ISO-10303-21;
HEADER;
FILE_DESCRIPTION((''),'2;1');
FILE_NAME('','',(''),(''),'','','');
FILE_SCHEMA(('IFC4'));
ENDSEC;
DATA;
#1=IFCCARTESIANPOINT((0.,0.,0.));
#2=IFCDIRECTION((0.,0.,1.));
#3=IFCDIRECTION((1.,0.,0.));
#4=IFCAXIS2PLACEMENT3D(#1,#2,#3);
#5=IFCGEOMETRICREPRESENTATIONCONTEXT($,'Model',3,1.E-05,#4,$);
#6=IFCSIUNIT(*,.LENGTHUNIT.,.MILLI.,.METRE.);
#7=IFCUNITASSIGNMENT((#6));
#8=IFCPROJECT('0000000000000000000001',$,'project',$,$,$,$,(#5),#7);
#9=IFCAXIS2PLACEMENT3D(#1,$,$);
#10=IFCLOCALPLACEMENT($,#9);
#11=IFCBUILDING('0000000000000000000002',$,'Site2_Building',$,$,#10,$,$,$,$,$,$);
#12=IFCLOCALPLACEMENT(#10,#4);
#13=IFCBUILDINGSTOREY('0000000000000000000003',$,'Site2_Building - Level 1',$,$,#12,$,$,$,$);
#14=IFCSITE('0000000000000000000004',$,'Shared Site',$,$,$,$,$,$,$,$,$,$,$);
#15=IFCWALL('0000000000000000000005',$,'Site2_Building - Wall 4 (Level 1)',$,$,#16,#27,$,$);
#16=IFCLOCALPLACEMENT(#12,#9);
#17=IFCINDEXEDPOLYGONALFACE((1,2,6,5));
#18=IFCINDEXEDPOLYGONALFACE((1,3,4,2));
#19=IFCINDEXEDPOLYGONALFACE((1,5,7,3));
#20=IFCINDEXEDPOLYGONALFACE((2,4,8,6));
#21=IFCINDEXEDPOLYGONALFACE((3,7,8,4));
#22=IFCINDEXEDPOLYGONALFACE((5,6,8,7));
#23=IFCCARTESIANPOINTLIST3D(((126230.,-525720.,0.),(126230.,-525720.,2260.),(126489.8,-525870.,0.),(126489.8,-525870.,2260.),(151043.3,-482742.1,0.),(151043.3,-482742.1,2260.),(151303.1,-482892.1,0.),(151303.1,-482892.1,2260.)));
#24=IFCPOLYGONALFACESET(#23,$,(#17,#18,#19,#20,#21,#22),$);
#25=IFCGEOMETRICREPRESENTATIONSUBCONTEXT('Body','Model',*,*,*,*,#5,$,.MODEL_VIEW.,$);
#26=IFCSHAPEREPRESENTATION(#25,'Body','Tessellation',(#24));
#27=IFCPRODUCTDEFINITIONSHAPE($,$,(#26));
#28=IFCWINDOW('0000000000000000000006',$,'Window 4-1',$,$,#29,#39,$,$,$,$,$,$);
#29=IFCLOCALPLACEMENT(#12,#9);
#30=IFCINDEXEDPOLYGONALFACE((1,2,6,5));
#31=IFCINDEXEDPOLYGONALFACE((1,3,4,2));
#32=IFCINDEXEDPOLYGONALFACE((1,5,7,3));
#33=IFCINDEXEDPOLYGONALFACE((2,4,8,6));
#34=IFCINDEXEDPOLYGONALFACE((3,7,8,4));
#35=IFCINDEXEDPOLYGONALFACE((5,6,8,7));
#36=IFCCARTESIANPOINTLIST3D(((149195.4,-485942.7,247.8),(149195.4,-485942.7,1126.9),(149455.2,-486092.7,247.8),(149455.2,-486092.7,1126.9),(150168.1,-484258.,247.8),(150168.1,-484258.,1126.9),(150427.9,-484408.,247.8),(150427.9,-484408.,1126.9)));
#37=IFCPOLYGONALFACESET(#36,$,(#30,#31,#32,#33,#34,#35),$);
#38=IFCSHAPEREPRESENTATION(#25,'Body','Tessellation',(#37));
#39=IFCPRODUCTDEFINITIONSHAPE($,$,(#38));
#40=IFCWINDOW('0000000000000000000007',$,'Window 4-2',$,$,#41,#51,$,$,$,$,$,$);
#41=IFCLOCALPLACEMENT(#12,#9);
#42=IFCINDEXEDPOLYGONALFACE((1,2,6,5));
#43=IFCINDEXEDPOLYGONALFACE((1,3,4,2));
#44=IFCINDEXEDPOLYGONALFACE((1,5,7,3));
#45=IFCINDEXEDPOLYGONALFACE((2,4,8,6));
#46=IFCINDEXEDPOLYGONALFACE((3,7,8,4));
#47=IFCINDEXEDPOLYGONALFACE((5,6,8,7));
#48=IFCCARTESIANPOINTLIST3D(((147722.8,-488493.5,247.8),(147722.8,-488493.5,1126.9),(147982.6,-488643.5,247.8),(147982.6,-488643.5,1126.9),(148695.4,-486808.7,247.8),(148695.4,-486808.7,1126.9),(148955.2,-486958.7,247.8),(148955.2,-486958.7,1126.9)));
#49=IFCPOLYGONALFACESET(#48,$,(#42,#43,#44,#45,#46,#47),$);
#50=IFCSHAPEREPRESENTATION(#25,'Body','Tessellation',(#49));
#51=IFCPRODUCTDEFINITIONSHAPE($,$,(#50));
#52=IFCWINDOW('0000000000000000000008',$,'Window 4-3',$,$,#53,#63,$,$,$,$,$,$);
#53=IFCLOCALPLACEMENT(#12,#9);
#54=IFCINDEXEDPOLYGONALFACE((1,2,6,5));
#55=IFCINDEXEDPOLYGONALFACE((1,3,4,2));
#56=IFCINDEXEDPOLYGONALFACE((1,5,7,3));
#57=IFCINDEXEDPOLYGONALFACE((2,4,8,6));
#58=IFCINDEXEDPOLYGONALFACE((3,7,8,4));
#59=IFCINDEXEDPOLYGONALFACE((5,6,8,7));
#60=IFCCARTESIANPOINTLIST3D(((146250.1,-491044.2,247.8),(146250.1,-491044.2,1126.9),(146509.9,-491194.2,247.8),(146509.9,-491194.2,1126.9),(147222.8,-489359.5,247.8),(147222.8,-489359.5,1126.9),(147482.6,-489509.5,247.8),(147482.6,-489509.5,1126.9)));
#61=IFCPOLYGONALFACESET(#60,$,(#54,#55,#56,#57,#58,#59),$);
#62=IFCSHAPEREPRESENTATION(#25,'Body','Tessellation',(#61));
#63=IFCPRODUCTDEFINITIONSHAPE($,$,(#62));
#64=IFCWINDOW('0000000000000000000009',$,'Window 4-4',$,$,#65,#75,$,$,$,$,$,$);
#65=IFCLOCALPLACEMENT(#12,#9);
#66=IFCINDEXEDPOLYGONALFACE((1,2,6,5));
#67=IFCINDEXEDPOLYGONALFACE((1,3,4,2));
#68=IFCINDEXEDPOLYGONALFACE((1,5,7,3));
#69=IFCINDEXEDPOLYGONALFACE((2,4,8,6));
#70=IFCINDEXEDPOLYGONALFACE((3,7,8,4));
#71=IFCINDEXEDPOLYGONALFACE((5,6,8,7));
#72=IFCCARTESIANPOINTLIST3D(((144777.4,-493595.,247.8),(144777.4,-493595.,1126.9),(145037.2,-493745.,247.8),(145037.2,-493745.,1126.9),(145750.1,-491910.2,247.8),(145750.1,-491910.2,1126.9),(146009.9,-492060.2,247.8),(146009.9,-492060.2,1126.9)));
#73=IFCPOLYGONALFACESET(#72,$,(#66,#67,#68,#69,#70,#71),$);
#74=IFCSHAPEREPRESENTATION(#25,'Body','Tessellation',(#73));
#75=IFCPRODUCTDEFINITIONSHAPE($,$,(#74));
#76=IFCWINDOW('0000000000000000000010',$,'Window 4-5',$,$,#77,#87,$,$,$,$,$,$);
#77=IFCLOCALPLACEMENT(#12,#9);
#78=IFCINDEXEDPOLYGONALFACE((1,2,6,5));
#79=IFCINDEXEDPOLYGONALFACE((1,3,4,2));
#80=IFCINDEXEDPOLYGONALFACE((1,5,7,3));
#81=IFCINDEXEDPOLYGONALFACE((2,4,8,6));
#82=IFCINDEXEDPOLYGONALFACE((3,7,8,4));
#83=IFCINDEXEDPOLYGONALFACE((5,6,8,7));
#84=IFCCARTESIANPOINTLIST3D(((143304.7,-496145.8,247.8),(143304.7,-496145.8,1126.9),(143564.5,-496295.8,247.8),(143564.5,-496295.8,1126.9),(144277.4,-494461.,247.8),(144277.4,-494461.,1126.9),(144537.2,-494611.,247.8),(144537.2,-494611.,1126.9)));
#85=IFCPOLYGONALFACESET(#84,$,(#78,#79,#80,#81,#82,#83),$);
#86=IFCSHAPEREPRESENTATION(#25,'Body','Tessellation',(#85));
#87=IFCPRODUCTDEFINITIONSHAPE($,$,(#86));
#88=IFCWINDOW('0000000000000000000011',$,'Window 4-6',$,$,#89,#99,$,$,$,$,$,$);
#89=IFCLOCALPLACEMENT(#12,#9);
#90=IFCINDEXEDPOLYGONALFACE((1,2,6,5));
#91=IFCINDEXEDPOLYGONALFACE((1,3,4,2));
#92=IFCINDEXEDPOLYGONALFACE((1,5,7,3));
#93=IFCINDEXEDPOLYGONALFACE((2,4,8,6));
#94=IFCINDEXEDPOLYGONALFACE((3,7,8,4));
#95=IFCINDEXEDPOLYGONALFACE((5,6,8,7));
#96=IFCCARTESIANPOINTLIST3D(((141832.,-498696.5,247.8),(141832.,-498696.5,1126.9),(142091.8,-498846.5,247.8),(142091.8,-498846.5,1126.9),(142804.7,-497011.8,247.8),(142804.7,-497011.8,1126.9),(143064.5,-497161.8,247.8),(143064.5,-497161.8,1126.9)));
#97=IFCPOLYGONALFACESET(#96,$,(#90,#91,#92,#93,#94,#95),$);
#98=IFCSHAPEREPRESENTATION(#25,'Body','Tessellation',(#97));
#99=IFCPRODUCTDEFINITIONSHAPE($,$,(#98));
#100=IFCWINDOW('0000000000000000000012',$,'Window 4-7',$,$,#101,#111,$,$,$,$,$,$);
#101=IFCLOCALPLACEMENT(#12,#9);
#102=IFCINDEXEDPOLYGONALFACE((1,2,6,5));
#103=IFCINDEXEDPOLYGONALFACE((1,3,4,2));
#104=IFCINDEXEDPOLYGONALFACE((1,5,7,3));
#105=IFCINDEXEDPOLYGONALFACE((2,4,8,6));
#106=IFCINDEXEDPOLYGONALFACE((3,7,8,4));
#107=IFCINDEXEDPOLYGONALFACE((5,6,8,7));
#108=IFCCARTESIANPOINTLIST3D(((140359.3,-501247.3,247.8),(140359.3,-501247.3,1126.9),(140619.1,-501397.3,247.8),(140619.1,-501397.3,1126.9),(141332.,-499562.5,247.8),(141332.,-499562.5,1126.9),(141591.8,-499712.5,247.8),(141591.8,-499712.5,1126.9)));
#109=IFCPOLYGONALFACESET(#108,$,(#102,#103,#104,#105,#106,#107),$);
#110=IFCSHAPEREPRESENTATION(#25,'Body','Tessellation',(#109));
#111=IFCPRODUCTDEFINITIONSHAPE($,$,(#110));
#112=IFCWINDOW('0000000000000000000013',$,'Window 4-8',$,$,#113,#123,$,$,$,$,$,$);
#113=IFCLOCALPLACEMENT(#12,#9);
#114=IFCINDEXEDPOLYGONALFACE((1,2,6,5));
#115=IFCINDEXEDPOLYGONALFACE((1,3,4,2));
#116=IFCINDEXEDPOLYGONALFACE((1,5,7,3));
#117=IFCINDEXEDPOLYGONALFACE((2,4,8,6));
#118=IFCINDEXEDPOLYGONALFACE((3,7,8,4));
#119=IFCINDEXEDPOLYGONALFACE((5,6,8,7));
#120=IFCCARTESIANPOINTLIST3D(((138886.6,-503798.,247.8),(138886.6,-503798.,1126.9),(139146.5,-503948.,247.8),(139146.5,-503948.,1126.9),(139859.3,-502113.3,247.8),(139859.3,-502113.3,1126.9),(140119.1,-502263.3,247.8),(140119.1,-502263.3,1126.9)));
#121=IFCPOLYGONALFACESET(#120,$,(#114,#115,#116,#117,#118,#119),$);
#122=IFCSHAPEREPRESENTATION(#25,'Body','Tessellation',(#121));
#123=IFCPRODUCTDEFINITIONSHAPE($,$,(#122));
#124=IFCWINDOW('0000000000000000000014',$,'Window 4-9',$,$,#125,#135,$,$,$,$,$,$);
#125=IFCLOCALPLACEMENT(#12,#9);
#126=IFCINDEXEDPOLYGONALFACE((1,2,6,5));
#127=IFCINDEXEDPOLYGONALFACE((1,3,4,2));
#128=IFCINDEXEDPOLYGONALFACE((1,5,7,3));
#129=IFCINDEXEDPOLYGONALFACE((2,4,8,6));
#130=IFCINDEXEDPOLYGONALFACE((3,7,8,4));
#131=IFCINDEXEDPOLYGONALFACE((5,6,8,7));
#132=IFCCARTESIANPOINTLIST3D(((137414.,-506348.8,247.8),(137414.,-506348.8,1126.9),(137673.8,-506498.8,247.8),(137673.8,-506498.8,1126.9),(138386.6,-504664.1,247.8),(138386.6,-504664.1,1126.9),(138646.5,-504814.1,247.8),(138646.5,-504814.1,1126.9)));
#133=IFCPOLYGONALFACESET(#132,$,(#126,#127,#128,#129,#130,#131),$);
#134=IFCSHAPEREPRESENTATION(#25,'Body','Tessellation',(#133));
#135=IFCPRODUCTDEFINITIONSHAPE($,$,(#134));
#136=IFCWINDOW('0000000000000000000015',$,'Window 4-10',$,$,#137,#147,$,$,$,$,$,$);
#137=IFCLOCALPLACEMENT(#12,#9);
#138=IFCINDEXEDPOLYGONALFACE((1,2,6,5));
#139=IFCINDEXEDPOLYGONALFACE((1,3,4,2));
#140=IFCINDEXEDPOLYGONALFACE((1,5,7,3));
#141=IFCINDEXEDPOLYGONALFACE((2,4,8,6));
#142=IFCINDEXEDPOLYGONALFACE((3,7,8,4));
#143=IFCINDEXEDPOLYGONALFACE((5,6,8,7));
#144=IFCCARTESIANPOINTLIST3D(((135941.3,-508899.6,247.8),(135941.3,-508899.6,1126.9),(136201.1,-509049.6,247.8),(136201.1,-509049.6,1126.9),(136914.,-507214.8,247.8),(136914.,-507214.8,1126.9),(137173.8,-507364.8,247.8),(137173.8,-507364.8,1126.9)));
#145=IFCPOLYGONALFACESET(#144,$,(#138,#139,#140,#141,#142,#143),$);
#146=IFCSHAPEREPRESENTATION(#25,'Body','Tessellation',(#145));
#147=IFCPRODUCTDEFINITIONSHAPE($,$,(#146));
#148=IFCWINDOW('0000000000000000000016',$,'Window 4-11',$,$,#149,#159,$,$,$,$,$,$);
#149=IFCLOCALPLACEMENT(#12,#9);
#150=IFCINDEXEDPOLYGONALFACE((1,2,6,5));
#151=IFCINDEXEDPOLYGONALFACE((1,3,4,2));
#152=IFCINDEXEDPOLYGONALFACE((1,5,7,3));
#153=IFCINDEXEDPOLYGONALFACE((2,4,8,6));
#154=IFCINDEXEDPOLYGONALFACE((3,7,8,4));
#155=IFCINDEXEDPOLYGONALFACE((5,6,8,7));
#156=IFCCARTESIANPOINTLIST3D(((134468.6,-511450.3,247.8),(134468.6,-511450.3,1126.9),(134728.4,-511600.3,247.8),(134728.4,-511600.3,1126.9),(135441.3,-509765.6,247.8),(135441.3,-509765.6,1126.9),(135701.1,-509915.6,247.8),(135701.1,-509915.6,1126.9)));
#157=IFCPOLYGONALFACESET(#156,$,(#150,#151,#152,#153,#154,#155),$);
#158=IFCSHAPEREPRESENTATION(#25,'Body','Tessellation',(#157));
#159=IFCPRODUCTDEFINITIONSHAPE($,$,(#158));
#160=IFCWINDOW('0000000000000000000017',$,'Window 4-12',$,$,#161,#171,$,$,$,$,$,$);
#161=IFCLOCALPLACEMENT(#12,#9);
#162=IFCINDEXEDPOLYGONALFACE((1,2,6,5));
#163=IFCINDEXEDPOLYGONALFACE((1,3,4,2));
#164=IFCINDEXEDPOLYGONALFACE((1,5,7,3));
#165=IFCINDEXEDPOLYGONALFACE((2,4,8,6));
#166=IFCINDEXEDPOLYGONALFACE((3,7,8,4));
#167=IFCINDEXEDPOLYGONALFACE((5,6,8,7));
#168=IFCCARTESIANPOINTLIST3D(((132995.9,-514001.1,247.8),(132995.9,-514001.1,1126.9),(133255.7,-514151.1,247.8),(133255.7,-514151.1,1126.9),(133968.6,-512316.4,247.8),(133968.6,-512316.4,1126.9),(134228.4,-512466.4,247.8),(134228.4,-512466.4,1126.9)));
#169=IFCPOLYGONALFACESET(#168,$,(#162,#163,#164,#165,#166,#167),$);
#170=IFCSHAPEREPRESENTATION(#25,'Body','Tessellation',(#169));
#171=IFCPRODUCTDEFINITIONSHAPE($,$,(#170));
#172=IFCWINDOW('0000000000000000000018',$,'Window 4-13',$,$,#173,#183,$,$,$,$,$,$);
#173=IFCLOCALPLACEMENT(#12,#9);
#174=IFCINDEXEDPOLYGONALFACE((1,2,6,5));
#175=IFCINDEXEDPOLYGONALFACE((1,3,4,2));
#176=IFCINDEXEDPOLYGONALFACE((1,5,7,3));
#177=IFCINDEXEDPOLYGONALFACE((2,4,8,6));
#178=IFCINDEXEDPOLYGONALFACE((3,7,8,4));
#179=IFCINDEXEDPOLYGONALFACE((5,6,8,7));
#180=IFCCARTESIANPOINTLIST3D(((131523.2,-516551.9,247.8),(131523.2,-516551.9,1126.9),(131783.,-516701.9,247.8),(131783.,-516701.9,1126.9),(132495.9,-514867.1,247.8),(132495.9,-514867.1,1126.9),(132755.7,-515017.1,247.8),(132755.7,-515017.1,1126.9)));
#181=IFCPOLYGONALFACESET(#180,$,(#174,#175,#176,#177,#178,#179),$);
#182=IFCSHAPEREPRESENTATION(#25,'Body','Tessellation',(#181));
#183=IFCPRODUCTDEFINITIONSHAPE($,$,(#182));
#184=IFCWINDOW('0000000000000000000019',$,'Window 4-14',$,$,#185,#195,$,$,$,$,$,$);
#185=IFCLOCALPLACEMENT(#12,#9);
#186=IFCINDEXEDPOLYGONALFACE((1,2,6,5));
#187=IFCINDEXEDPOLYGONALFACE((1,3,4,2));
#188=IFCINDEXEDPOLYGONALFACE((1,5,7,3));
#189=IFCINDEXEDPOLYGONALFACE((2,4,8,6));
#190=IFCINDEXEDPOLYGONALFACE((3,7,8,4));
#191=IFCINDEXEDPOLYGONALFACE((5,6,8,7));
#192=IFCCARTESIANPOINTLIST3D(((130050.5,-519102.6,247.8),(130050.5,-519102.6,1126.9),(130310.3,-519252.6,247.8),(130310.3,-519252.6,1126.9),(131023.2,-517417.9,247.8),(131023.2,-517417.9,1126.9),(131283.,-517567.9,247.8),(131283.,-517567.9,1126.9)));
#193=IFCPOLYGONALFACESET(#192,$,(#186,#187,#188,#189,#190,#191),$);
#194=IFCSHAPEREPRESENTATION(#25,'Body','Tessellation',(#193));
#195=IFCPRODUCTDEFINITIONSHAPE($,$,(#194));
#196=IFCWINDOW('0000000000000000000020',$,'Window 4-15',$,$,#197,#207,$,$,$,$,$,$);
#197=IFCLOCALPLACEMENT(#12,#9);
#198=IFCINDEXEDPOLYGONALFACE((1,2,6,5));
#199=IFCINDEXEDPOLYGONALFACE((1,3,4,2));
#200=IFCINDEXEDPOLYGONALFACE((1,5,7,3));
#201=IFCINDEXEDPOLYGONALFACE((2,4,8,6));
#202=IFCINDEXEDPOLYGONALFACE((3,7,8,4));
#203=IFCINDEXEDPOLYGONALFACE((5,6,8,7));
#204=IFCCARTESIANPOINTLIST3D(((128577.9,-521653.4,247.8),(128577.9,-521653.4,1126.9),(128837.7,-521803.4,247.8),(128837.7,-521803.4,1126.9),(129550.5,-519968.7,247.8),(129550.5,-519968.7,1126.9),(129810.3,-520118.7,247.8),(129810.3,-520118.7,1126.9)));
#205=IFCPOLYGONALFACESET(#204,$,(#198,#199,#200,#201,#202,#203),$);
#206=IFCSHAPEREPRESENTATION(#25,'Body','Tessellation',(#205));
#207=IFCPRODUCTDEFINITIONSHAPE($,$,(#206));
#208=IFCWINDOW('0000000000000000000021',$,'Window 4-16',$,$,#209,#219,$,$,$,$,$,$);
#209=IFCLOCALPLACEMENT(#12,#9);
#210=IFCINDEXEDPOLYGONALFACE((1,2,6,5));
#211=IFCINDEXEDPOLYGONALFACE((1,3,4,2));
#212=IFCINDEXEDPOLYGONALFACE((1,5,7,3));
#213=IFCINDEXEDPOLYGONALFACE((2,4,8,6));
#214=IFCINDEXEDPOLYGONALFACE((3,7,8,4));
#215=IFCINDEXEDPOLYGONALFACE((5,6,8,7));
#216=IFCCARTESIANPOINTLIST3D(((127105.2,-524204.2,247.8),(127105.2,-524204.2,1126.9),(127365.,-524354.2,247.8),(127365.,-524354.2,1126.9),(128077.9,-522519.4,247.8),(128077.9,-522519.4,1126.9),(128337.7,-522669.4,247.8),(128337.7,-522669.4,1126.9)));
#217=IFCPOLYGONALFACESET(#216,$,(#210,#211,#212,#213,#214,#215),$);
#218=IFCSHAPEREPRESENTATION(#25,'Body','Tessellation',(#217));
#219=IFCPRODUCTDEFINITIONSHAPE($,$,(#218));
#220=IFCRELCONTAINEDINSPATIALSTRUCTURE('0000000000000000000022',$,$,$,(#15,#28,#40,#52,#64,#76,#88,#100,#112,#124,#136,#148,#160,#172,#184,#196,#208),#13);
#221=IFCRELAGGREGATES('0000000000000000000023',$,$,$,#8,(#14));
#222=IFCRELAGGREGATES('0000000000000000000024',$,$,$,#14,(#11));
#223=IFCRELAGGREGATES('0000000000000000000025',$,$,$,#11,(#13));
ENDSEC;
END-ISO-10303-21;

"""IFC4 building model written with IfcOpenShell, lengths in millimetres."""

from ifc_helpers import new_model, si_unit, frame, origin, origin_with_axes, place, context, subcontext, project, spatial, indexed_curve, outline, extrude, element, save


model = new_model("IFC4")

# Units and contexts
model_context = context("Model", 3, precision=1e-05, world=origin_with_axes())
body_context = subcontext(model_context, "Body", "Model", "MODEL_VIEW")
ifc_project = project(units=[si_unit("LENGTHUNIT", "METRE", prefix="MILLI")], contexts=[model_context])

# Site, building, storey
site = spatial("IfcSite", under=ifc_project, Name="Shared Site")
building_placement = place(None, origin())
building = spatial("IfcBuilding", under=site, at=building_placement, Name="Site2_Building")
storey_placement = place(building_placement, origin_with_axes())
storey = spatial("IfcBuildingStorey", under=building, at=storey_placement, Name="Site2_Building - Level 1")

# Wall
wall_1_placement = place(storey_placement, frame((151043.3, -482742.1, 0.0), z_axis=(0.0, 0.0, 1.0), x_axis=(-0.5, -0.866025, 0.0)))
element("IfcWall", 1, at=wall_1_placement, inside=storey, Name="Site2_Building - Wall 4 (Level 1)", context=body_context, shape_type="SweptSolid", body=[
    extrude(outline(indexed_curve([(0.0, 0.0), (0.0, 300.0), (49626.6, 300.0), (49626.6, 0.0), (0.0, 0.0)], self_intersect=False)), origin_with_axes(), (0.0, 0.0, 1.0), 2260.0),
])

# Windows
for number, where, z_axis, x_axis, name in (
    (2, (150168.1, -484258.0, 247.8), (0.0, 0.0, 1.0), (-0.5, -0.866025, 0.0), "Window 4-1"),
    (3, (148695.4, -486808.7, 247.8), (0.0, 0.0, 1.0), (-0.5, -0.866025, 0.0), "Window 4-2"),
    (4, (147222.8, -489359.5, 247.8), (0.0, 0.0, 1.0), (-0.5, -0.866025, 0.0), "Window 4-3"),
    (5, (145750.1, -491910.2, 247.8), (0.0, 0.0, 1.0), (-0.5, -0.866025, 0.0), "Window 4-4"),
    (6, (144277.4, -494461.0, 247.8), (0.0, 0.0, 1.0), (-0.5, -0.866025, 0.0), "Window 4-5"),
    (7, (142804.7, -497011.8, 247.8), (0.0, 0.0, 1.0), (-0.5, -0.866025, 0.0), "Window 4-6"),
    (8, (141332.0, -499562.5, 247.8), (0.0, 0.0, 1.0), (-0.5, -0.866025, 0.0), "Window 4-7"),
    (9, (139859.3, -502113.3, 247.8), (0.0, 0.0, 1.0), (-0.5, -0.866025, 0.0), "Window 4-8"),
    (10, (138386.6, -504664.1, 247.8), (0.0, 0.0, 1.0), (-0.5, -0.866025, 0.0), "Window 4-9"),
    (11, (136914.0, -507214.8, 247.8), (0.0, 0.0, 1.0), (-0.5, -0.866025, 0.0), "Window 4-10"),
    (12, (135441.3, -509765.6, 247.8), (0.0, 0.0, 1.0), (-0.5, -0.866025, 0.0), "Window 4-11"),
    (13, (133968.6, -512316.4, 247.8), (0.0, 0.0, 1.0), (-0.5, -0.866025, 0.0), "Window 4-12"),
    (14, (132495.9, -514867.1, 247.8), (0.0, 0.0, 1.0), (-0.5, -0.866025, 0.0), "Window 4-13"),
    (15, (131023.2, -517417.9, 247.8), (0.0, 0.0, 1.0), (-0.5, -0.866025, 0.0), "Window 4-14"),
    (16, (129550.5, -519968.7, 247.8), (0.0, 0.0, 1.0), (-0.5, -0.866025, 0.0), "Window 4-15"),
    (17, (128077.9, -522519.4, 247.8), (0.0, 0.0, 1.0), (-0.5, -0.866025, 0.0), "Window 4-16"),
):
    element("IfcWindow", number, at=place(storey_placement, frame(where, z_axis=z_axis, x_axis=x_axis)), inside=storey, Name=name, context=body_context, shape_type="SweptSolid", body=[
        extrude(outline(indexed_curve([(0.0, 0.0), (0.0, 300.0), (1945.4, 300.0), (1945.4, 0.0), (0.0, 0.0)], self_intersect=False)), origin_with_axes(), (0.0, 0.0, 1.0), 879.1),
    ])

save(model, "model.ifc")
